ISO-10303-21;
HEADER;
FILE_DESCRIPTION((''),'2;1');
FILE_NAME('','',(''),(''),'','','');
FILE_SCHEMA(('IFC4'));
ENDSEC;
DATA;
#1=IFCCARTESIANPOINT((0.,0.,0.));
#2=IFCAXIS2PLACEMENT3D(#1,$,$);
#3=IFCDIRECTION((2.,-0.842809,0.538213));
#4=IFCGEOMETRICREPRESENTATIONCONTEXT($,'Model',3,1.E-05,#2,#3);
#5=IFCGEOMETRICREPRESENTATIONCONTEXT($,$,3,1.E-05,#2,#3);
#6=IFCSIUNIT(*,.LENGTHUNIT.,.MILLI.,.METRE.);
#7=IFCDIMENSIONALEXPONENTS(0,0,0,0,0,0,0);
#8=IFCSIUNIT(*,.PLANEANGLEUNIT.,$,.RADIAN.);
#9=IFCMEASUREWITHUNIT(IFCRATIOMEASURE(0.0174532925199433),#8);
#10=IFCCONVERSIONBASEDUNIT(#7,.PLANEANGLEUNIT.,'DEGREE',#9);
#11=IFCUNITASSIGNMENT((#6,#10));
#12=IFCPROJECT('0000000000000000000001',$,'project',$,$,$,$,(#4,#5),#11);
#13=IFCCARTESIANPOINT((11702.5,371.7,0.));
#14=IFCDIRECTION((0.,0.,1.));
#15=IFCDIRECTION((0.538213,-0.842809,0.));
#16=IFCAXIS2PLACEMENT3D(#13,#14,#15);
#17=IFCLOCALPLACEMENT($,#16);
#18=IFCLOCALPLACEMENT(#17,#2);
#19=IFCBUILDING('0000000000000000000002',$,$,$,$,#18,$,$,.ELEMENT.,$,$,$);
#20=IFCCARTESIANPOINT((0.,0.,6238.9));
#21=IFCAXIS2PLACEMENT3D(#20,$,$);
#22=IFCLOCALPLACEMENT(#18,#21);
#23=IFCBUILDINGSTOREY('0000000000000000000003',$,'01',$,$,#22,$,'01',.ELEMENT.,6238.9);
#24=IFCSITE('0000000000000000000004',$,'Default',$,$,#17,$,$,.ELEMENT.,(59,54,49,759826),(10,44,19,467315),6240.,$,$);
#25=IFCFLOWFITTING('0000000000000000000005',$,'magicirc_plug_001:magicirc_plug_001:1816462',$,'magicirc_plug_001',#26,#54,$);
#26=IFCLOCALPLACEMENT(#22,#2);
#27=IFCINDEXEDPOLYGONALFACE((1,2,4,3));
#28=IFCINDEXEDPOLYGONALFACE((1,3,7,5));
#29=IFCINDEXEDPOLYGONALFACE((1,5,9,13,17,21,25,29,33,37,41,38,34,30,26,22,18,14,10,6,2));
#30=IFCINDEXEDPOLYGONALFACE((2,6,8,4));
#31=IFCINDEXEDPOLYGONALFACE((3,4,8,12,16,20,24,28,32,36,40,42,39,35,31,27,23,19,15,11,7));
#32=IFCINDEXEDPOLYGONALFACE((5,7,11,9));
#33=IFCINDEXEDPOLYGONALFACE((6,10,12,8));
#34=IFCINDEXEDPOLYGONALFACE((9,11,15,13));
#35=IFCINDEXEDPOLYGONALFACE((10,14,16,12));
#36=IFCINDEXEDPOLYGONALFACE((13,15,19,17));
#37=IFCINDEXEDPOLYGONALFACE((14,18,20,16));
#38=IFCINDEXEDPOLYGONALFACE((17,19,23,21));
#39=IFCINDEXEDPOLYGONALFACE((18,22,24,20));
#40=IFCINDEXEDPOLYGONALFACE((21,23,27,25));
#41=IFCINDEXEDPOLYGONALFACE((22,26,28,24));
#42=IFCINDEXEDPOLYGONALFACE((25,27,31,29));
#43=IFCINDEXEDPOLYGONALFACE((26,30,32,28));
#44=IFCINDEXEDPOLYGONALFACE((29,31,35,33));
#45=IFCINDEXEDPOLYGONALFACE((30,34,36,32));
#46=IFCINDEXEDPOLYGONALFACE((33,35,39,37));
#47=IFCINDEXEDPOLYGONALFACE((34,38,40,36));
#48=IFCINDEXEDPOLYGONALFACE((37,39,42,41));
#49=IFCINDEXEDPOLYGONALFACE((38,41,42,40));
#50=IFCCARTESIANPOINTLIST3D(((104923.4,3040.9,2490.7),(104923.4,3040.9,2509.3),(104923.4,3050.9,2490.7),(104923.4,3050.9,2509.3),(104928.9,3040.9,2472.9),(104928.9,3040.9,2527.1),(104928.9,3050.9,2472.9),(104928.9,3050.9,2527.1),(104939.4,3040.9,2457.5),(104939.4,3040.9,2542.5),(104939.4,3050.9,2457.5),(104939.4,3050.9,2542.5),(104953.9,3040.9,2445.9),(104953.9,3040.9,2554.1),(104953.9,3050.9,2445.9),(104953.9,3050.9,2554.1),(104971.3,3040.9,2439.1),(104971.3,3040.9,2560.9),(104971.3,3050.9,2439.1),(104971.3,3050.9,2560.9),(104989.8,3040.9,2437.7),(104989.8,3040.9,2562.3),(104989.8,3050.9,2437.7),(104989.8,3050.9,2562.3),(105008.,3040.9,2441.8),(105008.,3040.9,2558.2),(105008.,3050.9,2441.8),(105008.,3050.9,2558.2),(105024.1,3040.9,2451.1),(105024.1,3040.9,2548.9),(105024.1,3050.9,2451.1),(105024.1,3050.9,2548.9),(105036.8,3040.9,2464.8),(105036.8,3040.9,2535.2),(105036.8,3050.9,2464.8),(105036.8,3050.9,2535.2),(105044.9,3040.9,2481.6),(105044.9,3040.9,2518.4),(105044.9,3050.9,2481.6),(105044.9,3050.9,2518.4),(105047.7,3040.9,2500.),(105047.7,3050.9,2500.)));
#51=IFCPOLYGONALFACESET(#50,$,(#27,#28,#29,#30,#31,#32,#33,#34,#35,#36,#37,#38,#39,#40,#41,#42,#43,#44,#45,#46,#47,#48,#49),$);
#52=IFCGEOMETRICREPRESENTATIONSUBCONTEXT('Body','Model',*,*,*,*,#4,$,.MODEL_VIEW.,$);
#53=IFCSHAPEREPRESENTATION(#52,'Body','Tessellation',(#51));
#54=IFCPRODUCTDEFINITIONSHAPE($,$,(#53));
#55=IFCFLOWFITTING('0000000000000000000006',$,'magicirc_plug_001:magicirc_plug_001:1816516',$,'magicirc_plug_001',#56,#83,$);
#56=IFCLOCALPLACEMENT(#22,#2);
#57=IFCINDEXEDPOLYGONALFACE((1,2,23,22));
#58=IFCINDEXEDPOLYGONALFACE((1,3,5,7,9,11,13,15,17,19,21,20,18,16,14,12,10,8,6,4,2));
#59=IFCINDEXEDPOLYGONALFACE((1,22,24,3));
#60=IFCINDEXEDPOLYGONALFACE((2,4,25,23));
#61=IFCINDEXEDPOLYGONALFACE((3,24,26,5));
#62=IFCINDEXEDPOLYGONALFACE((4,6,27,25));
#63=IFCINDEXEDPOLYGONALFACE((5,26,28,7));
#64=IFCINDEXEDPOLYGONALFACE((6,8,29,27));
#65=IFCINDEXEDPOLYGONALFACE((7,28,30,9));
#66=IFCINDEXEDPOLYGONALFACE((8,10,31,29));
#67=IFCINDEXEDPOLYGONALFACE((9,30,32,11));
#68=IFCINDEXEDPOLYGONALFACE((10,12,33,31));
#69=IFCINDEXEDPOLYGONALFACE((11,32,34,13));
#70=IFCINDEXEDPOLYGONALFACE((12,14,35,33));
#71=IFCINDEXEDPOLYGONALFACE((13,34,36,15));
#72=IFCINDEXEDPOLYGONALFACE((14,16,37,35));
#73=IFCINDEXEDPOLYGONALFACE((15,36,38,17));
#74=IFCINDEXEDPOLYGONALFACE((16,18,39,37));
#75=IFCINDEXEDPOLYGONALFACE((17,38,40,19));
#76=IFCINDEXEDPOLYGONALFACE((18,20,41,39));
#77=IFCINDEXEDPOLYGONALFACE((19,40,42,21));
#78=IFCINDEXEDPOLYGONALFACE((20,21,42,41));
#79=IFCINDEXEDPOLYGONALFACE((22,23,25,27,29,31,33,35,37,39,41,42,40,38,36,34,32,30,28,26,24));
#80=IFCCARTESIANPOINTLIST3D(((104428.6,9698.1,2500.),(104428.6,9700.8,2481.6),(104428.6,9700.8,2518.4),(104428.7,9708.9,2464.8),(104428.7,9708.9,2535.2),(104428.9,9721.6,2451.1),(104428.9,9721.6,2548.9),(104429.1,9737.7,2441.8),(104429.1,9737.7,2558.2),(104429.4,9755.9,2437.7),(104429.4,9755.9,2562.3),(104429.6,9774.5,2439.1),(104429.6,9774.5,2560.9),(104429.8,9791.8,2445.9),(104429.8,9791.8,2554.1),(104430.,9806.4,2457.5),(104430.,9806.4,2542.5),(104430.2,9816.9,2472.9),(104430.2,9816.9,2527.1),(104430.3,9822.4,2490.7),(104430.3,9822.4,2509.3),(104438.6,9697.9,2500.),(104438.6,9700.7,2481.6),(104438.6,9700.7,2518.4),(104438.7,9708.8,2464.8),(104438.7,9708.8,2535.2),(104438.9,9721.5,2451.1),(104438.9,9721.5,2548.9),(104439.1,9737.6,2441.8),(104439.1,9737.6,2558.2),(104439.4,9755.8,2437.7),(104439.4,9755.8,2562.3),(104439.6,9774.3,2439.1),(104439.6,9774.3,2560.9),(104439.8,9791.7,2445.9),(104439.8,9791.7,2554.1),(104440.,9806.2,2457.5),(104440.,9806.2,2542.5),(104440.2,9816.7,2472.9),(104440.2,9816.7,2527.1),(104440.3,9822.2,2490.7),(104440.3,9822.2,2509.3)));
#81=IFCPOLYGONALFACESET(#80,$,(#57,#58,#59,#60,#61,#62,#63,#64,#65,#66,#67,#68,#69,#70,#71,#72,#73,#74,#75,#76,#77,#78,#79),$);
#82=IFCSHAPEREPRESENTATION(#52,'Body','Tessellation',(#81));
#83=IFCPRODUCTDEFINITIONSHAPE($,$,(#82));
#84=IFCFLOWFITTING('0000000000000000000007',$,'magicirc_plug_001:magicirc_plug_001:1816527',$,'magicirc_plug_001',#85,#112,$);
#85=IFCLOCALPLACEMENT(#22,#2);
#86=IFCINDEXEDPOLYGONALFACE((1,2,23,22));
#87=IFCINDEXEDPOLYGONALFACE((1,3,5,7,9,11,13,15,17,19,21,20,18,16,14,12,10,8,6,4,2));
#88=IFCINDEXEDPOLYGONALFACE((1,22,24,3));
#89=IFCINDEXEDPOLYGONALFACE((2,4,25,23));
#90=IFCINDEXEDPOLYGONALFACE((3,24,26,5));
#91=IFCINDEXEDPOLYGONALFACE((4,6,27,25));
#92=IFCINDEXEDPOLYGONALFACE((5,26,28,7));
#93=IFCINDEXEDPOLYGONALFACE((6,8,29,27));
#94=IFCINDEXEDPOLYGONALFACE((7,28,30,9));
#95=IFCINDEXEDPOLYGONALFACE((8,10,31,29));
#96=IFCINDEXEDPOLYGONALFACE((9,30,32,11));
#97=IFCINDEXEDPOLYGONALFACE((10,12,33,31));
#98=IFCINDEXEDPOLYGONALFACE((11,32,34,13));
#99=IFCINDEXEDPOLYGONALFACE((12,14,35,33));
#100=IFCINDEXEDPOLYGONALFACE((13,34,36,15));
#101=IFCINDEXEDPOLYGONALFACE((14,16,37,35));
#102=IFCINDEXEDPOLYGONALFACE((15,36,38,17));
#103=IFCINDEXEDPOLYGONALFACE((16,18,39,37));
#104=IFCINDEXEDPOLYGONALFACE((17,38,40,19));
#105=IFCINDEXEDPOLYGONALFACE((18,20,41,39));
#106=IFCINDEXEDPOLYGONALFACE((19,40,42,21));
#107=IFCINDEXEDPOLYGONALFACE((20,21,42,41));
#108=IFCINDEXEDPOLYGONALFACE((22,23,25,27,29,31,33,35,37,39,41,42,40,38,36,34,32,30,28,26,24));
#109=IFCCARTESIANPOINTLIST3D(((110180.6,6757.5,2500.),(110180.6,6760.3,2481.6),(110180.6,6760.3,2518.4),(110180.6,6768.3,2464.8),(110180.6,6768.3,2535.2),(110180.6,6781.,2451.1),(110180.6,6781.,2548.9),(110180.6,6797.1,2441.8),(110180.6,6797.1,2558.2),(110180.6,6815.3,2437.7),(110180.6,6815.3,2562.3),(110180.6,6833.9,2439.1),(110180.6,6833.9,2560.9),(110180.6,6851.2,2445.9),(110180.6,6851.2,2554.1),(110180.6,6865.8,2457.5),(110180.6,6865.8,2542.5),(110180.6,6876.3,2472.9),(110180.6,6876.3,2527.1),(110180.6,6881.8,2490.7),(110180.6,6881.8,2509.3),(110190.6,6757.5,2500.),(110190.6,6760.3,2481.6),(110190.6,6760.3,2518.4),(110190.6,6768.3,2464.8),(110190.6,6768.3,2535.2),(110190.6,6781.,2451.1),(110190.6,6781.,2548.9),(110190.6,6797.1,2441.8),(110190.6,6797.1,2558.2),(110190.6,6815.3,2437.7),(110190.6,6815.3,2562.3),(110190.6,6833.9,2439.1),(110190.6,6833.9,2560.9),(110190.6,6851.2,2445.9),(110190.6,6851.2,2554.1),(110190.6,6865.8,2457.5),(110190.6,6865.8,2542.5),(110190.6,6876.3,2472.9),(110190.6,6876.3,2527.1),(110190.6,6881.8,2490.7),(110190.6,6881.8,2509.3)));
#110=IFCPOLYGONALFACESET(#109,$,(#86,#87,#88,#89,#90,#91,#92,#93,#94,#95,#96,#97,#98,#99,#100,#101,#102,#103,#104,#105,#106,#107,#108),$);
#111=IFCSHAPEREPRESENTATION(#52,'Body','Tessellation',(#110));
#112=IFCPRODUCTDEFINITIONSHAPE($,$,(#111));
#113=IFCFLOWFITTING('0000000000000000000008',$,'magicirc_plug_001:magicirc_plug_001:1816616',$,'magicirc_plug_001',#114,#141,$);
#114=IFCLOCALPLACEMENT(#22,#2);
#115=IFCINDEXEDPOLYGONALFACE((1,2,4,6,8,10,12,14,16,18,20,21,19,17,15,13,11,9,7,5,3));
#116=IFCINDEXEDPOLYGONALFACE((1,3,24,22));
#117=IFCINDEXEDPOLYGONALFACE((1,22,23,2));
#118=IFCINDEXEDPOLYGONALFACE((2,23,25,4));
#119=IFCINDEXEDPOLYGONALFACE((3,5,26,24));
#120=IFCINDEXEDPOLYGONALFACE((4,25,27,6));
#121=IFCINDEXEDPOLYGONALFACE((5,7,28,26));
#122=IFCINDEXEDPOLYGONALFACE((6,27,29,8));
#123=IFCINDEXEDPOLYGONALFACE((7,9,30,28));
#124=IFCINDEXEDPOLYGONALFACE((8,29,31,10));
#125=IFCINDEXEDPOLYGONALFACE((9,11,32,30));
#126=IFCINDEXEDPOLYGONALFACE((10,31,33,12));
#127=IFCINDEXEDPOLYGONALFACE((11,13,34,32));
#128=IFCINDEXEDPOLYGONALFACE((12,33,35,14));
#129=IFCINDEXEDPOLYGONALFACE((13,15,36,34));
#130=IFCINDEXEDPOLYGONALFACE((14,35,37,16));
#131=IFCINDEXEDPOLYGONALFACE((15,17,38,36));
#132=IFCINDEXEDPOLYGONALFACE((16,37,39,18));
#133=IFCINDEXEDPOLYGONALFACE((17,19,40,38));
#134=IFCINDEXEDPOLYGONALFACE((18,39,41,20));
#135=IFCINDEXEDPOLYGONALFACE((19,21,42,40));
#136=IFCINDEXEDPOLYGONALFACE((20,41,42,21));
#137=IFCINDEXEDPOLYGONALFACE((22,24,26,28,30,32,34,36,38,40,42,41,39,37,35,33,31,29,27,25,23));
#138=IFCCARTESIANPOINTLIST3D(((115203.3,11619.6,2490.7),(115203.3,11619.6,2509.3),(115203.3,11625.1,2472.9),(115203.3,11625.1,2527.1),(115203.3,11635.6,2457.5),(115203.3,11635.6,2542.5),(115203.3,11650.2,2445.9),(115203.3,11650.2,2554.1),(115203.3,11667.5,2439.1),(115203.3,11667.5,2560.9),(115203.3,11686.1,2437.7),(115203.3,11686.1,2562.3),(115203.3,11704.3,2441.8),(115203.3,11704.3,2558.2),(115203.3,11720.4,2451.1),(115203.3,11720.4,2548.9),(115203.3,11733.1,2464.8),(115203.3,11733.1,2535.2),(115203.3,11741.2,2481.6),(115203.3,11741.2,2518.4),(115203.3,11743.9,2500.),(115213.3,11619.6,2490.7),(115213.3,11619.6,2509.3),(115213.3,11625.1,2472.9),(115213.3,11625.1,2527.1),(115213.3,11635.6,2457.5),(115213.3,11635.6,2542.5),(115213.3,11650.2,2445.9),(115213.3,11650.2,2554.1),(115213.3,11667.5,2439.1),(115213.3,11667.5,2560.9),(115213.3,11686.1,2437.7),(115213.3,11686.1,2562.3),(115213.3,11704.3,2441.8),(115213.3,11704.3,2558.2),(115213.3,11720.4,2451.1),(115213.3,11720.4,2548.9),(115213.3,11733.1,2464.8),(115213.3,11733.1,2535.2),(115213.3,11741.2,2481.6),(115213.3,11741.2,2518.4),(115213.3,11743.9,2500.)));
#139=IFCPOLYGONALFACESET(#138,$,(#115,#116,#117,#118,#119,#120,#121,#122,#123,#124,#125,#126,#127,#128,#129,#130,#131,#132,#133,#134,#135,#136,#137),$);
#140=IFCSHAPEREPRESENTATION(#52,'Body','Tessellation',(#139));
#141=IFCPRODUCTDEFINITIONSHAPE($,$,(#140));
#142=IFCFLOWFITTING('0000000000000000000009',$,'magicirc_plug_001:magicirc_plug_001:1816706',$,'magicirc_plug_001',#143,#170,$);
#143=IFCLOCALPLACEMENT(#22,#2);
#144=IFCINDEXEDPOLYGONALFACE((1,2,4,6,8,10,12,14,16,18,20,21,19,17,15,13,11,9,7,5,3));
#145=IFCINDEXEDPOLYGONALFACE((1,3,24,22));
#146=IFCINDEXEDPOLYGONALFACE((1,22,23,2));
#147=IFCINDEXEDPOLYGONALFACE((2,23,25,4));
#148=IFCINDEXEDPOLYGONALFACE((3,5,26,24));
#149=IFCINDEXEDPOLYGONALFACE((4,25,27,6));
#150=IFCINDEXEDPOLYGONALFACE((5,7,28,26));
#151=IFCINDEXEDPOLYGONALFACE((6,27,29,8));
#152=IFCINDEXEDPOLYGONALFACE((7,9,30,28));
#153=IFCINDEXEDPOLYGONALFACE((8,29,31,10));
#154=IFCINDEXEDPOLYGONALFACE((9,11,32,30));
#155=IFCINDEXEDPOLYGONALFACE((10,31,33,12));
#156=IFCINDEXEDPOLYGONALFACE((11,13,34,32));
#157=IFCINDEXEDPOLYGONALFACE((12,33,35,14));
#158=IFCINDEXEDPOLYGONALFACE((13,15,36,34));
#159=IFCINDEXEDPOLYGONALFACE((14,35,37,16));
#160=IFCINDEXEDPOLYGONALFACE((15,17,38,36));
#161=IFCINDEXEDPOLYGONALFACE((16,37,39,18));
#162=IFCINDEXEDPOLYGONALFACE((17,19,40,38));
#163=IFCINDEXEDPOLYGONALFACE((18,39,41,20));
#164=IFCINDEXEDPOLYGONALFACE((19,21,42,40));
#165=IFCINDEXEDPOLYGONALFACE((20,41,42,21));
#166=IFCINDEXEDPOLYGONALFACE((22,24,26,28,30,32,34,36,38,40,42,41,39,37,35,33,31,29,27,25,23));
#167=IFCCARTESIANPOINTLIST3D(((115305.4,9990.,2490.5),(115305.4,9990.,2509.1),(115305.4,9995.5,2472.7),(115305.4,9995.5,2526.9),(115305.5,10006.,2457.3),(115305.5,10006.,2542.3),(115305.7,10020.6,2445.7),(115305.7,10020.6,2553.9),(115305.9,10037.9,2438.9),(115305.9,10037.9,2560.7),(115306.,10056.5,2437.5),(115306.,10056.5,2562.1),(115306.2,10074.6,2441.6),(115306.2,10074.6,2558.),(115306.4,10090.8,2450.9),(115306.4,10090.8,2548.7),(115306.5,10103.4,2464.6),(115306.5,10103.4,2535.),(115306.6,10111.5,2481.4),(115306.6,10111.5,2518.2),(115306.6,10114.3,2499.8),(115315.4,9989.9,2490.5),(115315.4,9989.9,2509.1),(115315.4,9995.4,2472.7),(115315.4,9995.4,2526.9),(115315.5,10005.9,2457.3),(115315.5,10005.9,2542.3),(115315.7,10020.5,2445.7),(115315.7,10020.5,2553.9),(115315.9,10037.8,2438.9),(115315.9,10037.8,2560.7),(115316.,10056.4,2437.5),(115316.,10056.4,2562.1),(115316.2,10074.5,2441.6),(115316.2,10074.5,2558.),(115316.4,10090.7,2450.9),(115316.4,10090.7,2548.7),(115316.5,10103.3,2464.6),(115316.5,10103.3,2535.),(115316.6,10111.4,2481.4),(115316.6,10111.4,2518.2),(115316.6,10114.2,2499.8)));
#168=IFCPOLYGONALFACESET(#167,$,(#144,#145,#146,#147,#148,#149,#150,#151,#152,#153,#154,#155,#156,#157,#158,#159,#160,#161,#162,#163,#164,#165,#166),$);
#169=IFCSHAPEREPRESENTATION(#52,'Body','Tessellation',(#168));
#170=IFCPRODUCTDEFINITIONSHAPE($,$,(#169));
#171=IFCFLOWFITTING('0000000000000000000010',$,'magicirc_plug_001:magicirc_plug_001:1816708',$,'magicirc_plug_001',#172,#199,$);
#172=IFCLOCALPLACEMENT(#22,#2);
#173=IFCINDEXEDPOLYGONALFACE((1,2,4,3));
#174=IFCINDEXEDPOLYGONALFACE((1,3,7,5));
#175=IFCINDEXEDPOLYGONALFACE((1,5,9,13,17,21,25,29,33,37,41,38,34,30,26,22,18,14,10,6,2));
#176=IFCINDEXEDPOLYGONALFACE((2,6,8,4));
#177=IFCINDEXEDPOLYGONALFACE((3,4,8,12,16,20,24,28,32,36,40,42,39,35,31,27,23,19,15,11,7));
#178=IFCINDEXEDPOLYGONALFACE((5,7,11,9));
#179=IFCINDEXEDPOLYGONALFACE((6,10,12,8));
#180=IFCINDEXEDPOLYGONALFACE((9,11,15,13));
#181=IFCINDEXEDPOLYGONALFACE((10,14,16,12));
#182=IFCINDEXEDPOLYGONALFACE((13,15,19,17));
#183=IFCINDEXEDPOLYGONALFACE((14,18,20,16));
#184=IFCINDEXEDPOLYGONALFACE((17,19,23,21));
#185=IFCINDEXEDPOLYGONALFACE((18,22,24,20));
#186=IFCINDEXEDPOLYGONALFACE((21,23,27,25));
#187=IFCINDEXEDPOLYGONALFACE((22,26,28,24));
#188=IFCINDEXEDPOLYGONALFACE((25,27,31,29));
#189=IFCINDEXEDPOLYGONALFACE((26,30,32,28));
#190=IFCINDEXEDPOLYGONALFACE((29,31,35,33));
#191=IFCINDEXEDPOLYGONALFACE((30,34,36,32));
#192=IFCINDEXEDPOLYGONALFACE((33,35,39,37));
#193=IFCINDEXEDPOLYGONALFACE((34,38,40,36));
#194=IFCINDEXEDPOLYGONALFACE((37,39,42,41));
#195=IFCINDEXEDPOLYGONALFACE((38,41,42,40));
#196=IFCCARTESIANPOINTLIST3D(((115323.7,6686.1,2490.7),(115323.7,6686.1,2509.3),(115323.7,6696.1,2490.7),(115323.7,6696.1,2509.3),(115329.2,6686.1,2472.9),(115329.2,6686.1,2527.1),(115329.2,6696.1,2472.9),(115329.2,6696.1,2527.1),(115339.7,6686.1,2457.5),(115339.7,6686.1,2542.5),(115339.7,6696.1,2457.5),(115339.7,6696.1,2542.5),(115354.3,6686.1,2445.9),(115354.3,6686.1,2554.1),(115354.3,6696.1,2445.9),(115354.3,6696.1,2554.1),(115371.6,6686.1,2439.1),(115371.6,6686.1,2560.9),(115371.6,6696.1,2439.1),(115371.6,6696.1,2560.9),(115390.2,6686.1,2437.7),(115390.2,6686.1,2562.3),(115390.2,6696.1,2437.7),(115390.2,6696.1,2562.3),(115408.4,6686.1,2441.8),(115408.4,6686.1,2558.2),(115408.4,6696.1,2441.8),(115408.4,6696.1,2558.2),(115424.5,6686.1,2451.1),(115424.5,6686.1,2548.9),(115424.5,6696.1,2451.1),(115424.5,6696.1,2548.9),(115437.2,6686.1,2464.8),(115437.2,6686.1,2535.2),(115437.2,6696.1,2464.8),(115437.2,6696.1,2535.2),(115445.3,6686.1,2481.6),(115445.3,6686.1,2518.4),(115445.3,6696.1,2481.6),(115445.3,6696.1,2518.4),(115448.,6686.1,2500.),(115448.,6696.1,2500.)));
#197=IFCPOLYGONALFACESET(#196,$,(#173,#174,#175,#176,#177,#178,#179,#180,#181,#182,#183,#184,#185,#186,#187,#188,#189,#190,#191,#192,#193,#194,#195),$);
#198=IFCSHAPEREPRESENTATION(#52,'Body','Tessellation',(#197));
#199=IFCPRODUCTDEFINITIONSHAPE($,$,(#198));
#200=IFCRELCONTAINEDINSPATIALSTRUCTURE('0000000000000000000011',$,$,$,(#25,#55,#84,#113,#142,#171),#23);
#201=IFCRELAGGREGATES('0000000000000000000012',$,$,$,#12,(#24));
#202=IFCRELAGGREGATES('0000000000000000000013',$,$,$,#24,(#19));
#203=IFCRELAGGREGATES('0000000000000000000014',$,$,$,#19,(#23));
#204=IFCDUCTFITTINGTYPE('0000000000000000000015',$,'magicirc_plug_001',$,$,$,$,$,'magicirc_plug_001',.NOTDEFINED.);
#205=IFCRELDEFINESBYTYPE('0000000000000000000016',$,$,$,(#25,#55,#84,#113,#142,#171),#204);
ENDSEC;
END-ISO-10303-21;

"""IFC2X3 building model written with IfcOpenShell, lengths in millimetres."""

from ifc_helpers import new_model, entity, si_unit, converted_unit, direction, frame, frame_2d, origin, place, context, subcontext, project, spatial, circle, extrude, source, transform, mapped, type_object, type_shapes, element, save


model = new_model("IFC2X3")

# Units and contexts
model_context = context("Model", 3, precision=1e-05, world=origin(), true_north=direction((2.0, -0.842809, 0.538213)))
context_of_model = context(None, 3, precision=1e-05, world=origin(), true_north=direction((2.0, -0.842809, 0.538213)))
body_context = subcontext(model_context, "Body", "Model", "MODEL_VIEW")
ifc_project = project(units=[si_unit("LENGTHUNIT", "METRE", prefix="MILLI"), converted_unit("PLANEANGLEUNIT", "DEGREE", entity("IfcRatioMeasure", 0.0174532925199433), si_unit("PLANEANGLEUNIT", "RADIAN"), dimensions=[0, 0, 0, 0, 0, 0, 0])], contexts=[model_context, context_of_model])

# Site, building, storey
site_placement = place(None, frame((11702.5, 371.7, 0.0), z_axis=(0.0, 0.0, 1.0), x_axis=(0.538213, -0.842809, 0.0)))
site = spatial("IfcSite", under=ifc_project, at=site_placement, Name="Default", CompositionType="ELEMENT", RefLatitude=(59, 54, 49, 759826), RefLongitude=(10, 44, 19, 467315), RefElevation=6240.0)
building_placement = place(site_placement, origin())
building = spatial("IfcBuilding", under=site, at=building_placement, CompositionType="ELEMENT")
storey_placement = place(building_placement, frame((0.0, 0.0, 6238.9)))
storey = spatial("IfcBuildingStorey", under=building, at=storey_placement, Name="01", LongName="01", CompositionType="ELEMENT", Elevation=6238.9)

# Flow fittings
duct_fitting_type_1 = type_object("IfcDuctFittingType", Name="magicirc_plug_001", ElementType="magicirc_plug_001", PredefinedType="NOTDEFINED")
shared_shape_1 = source(origin(), body_context, "Body", "SweptSolid", [
    extrude(circle(Radius=62.5, at=frame_2d((0.0, 0.0), x_axis=(1.0, 0.0))), frame((0.0, 0.0, 0.0), z_axis=(1.0, 0.0, 0.0), x_axis=(0.0, 1.0, 0.0)), (0.0, 0.0, 1.0), 10.0),
])
type_shapes(duct_fitting_type_1, [shared_shape_1])
for number, where, z_axis, x_axis, name in (
    (1, (104985.2, 3050.9, 2500.0), (0.0, 0.0, 1.0), (0.0, -1.0, 0.0), "magicirc_plug_001:magicirc_plug_001:1816462"),
    (2, (104439.4, 9760.4, 2500.0), (0.0, 0.0, 1.0), (-0.999911, 0.013345, 0.0), "magicirc_plug_001:magicirc_plug_001:1816516"),
    (3, (110190.6, 6820.0, 2500.0), (0.0, 0.0, 1.0), (-1.0, 0.0, 0.0), "magicirc_plug_001:magicirc_plug_001:1816527"),
):
    element("IfcFlowFitting", number, at=place(storey_placement, frame(where, z_axis=z_axis, x_axis=x_axis)), inside=storey, type_object=duct_fitting_type_1, Name=name, ObjectType="magicirc_plug_001", context=body_context, shape_type="MappedRepresentation", body=[
        mapped(shared_shape_1, transform((0.0, 0.0, 0.0), scale=1.0)),
    ])
flow_fitting_placement = place(storey_placement, frame((115203.3, 11681.4, 2500.0)))
element("IfcFlowFitting", 4, at=flow_fitting_placement, inside=storey, type_object=duct_fitting_type_1, Name="magicirc_plug_001:magicirc_plug_001:1816616", ObjectType="magicirc_plug_001", context=body_context, shape_type="MappedRepresentation", body=[
    mapped(shared_shape_1, transform((0.0, 0.0, 0.0), scale=1.0)),
])
for number, where, z_axis, x_axis, name in (
    (5, (115306.0, 10051.8, 2499.8), (-0.000017, 0.0, 1.0), (0.999952, -0.00981, 0.000017), "magicirc_plug_001:magicirc_plug_001:1816706"),
    (6, (115385.5, 6696.1, 2500.0), (0.0, 0.0, 1.0), (0.0, -1.0, 0.0), "magicirc_plug_001:magicirc_plug_001:1816708"),
):
    element("IfcFlowFitting", number, at=place(storey_placement, frame(where, z_axis=z_axis, x_axis=x_axis)), inside=storey, type_object=duct_fitting_type_1, Name=name, ObjectType="magicirc_plug_001", context=body_context, shape_type="MappedRepresentation", body=[
        mapped(shared_shape_1, transform((0.0, 0.0, 0.0), scale=1.0)),
    ])

save(model, "model.ifc")
